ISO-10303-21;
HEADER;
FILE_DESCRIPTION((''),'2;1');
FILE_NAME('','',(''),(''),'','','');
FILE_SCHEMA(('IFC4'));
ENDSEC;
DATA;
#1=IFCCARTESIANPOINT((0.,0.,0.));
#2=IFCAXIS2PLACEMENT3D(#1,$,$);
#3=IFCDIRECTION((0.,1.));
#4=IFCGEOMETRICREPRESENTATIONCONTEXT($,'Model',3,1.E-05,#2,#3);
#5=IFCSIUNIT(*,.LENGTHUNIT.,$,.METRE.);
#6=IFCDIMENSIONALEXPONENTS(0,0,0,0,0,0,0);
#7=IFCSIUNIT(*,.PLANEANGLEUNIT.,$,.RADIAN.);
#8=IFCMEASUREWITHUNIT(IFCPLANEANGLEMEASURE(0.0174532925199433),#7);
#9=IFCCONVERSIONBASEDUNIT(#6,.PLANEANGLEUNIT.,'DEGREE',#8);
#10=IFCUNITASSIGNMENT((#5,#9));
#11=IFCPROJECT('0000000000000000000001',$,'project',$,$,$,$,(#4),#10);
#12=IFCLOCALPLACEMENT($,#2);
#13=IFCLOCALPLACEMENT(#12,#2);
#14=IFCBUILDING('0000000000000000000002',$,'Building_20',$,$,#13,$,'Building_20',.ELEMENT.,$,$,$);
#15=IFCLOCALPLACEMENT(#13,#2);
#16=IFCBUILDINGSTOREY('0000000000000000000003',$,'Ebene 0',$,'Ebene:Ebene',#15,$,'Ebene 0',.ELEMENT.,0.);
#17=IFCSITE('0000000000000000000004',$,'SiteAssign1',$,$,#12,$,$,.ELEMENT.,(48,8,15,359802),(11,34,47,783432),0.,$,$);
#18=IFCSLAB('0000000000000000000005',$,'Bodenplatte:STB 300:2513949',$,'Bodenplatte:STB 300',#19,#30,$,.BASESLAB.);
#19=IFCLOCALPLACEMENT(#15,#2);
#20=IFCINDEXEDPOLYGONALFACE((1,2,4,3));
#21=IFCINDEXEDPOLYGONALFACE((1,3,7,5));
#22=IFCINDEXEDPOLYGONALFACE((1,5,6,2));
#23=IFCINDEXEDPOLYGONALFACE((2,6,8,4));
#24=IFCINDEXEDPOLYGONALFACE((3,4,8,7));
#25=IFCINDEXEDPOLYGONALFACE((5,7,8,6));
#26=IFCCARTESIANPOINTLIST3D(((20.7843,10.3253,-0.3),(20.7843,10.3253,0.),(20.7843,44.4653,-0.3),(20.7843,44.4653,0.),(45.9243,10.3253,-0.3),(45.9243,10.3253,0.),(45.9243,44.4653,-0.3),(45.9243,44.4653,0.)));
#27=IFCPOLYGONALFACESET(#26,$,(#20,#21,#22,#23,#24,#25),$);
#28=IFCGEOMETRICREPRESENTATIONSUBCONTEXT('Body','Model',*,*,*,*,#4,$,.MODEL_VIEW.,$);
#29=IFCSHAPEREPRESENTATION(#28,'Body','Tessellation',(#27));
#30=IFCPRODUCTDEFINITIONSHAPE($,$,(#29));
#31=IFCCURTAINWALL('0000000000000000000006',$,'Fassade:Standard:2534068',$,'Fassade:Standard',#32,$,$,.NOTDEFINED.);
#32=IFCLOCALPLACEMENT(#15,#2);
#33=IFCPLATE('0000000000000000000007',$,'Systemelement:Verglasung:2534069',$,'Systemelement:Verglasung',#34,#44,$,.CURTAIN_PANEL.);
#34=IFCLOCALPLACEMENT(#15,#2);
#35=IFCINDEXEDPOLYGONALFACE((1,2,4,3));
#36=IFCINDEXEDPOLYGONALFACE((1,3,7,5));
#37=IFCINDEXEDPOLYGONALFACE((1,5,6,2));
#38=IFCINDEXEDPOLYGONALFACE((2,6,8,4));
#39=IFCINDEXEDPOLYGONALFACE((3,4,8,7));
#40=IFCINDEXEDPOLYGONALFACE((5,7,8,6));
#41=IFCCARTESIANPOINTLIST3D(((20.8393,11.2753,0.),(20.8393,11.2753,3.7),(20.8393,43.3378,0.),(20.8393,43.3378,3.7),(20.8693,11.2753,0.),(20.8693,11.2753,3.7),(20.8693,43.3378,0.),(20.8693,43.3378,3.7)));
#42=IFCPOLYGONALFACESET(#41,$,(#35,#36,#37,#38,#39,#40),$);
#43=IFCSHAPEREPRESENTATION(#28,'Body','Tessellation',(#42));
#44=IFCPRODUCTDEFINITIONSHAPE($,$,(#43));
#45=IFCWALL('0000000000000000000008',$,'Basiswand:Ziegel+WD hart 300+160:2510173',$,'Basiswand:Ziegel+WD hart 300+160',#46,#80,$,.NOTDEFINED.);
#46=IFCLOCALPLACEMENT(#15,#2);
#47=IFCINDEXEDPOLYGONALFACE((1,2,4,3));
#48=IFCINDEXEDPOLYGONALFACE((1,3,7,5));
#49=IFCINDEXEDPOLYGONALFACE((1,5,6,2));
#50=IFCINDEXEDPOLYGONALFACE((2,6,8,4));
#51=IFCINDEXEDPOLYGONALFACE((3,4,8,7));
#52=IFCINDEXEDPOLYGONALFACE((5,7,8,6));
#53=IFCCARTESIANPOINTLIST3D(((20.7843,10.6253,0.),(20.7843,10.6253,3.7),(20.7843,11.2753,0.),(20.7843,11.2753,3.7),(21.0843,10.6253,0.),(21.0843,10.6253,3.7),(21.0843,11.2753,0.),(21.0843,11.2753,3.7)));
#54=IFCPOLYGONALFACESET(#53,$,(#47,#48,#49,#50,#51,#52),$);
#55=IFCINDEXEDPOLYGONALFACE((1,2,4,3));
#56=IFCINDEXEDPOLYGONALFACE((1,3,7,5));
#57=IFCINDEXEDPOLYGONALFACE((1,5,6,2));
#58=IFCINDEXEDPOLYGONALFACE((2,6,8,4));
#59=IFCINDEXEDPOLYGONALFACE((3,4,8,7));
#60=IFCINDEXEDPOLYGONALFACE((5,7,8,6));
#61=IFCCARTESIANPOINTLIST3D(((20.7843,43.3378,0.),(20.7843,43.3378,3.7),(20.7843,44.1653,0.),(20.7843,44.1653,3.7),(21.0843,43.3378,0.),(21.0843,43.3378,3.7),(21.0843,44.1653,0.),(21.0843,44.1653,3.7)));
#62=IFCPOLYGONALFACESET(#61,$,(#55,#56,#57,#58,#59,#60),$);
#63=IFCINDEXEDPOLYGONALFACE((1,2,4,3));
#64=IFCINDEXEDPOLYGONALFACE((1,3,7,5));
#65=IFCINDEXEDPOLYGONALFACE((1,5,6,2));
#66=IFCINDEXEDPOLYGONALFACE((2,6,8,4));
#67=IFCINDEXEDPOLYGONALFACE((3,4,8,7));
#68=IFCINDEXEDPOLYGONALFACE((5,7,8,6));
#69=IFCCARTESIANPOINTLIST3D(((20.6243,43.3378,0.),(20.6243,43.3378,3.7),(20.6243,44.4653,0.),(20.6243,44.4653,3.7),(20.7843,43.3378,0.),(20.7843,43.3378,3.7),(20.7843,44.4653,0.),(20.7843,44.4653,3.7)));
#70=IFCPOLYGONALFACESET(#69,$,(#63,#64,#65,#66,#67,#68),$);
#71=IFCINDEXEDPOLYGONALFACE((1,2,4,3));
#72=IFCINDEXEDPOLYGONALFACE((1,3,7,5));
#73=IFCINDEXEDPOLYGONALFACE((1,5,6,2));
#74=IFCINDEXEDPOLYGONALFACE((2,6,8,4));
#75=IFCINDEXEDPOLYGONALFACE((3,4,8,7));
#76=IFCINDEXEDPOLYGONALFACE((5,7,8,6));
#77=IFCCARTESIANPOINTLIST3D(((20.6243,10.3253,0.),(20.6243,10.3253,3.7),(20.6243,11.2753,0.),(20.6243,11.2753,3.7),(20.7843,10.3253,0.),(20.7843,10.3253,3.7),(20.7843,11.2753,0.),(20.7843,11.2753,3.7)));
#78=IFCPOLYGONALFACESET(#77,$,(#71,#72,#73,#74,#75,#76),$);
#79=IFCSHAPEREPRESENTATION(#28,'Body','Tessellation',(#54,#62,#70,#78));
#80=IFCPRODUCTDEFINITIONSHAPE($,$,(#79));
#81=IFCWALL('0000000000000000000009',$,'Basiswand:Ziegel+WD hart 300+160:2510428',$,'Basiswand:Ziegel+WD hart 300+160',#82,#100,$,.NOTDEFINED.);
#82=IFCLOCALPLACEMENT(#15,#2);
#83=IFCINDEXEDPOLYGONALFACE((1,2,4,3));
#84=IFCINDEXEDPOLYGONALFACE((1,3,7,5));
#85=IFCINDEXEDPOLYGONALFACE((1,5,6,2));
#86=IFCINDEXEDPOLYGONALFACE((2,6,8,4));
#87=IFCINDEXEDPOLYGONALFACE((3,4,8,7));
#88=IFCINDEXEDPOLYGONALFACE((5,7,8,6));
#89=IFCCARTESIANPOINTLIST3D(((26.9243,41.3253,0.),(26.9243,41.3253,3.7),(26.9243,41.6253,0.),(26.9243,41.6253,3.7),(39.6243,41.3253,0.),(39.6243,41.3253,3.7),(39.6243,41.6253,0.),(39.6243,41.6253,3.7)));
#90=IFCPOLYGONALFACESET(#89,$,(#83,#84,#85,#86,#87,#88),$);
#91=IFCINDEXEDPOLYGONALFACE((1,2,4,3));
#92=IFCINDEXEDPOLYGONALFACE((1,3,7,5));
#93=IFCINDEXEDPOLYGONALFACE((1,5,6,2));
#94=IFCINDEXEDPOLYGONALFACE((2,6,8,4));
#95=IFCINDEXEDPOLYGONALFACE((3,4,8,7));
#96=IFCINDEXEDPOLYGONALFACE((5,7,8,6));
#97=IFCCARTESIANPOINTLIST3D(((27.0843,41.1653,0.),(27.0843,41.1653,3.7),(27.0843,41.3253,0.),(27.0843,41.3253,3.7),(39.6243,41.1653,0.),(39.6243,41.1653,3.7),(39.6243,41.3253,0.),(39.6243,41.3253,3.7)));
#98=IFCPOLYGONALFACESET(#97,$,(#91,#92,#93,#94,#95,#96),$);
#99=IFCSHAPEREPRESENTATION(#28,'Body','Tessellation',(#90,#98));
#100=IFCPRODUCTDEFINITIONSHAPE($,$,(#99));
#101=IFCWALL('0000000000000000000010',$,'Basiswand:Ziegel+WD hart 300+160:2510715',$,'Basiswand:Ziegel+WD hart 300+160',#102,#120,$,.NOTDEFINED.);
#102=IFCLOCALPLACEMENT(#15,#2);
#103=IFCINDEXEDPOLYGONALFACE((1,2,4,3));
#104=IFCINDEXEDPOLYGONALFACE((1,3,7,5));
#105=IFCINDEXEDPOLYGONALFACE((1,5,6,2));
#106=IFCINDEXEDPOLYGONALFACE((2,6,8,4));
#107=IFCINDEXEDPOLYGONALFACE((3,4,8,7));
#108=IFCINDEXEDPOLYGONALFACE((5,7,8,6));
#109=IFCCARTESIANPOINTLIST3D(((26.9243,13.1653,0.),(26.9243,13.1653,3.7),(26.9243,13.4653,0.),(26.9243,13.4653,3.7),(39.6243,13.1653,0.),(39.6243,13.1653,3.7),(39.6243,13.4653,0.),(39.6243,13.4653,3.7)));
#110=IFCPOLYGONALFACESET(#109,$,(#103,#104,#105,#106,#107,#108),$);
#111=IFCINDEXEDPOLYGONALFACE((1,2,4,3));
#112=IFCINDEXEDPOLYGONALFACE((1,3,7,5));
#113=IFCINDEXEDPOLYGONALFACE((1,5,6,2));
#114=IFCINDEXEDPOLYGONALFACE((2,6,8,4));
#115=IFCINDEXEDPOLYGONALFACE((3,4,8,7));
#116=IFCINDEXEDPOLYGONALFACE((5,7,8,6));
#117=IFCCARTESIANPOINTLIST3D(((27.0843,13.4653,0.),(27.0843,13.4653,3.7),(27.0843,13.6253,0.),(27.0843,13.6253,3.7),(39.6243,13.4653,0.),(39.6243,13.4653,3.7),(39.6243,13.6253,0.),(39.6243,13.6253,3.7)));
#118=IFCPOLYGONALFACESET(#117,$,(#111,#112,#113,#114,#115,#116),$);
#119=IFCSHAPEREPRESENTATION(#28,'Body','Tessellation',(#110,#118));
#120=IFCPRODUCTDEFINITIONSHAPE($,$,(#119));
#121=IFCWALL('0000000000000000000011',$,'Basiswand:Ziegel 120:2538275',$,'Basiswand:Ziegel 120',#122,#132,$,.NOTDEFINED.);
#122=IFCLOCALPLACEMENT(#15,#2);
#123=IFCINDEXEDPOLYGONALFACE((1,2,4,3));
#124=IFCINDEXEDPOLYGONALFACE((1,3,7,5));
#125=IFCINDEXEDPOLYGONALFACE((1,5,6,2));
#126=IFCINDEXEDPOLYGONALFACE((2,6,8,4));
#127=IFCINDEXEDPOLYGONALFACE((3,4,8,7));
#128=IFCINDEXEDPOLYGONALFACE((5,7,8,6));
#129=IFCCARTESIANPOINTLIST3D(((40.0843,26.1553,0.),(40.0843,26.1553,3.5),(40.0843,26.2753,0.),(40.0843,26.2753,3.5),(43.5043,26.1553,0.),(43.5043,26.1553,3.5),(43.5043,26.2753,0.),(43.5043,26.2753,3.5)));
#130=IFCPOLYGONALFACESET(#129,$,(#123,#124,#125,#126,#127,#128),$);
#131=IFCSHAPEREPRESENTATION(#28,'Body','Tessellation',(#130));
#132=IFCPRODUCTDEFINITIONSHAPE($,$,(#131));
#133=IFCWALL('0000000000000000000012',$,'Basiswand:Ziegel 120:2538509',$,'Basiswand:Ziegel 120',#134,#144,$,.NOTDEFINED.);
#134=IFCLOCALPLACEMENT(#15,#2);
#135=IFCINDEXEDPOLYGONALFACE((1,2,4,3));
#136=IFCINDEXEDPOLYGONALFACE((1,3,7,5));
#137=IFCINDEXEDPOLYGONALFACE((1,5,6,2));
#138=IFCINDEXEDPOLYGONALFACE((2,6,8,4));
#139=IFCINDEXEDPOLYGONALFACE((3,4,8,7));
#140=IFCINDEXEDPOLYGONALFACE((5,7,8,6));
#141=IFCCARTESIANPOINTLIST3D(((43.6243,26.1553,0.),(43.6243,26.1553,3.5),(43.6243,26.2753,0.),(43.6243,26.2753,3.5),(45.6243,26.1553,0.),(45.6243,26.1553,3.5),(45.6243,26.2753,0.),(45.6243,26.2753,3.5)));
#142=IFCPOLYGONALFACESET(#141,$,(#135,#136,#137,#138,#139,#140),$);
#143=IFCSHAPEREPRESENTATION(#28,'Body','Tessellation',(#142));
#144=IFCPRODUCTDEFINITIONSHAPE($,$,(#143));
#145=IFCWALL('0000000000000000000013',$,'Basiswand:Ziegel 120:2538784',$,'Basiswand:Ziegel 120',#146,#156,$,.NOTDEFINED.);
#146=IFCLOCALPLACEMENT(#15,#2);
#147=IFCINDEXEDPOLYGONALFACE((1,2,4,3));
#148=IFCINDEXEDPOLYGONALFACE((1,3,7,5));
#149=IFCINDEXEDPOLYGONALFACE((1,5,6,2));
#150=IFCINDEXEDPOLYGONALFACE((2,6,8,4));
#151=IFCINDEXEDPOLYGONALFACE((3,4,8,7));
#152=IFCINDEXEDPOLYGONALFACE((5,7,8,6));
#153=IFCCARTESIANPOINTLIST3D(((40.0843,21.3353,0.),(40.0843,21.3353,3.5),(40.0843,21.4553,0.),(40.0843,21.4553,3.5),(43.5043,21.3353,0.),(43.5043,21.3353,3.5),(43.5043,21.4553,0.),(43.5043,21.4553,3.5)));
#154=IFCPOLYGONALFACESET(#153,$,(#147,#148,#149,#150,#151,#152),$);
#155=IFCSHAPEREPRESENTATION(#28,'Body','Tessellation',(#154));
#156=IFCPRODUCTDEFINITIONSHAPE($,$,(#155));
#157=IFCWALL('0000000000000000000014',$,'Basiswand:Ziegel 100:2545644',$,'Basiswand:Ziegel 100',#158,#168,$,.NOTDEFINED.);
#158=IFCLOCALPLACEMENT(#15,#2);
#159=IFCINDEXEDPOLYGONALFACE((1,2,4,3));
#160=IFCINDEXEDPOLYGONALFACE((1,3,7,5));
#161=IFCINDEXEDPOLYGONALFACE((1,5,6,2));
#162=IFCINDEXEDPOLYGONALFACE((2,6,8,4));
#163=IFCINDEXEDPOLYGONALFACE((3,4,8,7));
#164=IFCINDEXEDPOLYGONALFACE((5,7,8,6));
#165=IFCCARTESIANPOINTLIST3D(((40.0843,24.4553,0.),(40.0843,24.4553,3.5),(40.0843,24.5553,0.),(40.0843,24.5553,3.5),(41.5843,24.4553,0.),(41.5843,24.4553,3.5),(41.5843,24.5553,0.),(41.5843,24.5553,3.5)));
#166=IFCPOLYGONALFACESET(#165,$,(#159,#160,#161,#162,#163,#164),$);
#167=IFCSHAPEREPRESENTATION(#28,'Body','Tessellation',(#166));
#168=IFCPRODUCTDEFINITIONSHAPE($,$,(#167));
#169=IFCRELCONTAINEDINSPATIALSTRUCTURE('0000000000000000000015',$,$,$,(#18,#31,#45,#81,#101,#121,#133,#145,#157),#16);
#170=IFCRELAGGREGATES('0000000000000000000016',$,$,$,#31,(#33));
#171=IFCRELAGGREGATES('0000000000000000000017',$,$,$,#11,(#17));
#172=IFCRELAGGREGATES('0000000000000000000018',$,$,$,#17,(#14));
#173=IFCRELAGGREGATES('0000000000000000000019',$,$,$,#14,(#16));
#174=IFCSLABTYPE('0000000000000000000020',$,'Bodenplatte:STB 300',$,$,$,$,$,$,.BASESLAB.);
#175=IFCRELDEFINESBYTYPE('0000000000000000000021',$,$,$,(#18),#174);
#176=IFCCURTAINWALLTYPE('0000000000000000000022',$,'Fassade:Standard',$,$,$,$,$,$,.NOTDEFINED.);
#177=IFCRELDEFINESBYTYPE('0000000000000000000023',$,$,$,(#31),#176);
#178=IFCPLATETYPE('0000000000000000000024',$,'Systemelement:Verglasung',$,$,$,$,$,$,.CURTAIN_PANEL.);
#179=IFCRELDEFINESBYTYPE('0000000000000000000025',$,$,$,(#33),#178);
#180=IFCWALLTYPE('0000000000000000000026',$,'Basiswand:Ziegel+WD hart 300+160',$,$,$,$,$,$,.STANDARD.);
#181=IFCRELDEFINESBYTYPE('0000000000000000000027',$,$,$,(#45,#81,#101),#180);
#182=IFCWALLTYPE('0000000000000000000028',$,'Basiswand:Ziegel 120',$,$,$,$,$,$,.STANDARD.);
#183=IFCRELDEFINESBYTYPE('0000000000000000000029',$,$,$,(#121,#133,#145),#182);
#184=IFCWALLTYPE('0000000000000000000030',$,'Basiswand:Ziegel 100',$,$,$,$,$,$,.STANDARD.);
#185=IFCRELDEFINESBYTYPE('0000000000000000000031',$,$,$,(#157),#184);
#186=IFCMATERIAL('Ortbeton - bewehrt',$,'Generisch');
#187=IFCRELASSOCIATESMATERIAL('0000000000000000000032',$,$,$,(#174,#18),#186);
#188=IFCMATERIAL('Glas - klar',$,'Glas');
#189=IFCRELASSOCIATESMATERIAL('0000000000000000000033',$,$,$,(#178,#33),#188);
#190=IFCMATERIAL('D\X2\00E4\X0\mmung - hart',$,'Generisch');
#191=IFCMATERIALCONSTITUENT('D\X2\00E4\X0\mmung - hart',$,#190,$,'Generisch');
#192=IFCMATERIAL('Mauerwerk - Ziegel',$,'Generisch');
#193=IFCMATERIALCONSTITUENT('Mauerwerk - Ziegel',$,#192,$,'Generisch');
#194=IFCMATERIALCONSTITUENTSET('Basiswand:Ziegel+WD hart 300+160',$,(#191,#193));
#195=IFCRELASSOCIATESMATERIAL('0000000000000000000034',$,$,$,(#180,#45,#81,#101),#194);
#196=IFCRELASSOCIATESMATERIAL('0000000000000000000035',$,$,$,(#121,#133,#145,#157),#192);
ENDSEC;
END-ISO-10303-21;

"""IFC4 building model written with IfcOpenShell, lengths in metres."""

from ifc_helpers import new_model, entity, si_unit, converted_unit, direction, frame, origin, place, context, subcontext, project, spatial, indexed_curve, outline, extrude, source, transform, mapped, material, constituent, constituent_set, type_object, type_shapes, element, aggregate, save


model = new_model("IFC4")

# Units and contexts
model_context = context("Model", 3, precision=1e-05, world=origin(), true_north=direction((0.0, 1.0)))
body_context = subcontext(model_context, "Body", "Model", "MODEL_VIEW")
ifc_project = project(units=[si_unit("LENGTHUNIT", "METRE"), converted_unit("PLANEANGLEUNIT", "DEGREE", entity("IfcPlaneAngleMeasure", 0.0174532925199433), si_unit("PLANEANGLEUNIT", "RADIAN"), dimensions=[0, 0, 0, 0, 0, 0, 0])], contexts=[model_context])

# Site, building, storey
site_placement = place(None, origin())
site = spatial("IfcSite", under=ifc_project, at=site_placement, Name="SiteAssign1", CompositionType="ELEMENT", RefLatitude=(48, 8, 15, 359802), RefLongitude=(11, 34, 47, 783432), RefElevation=0.0)
building_placement = place(site_placement, origin())
building = spatial("IfcBuilding", under=site, at=building_placement, Name="Building_20", LongName="Building_20", CompositionType="ELEMENT")
storey_placement = place(building_placement, origin())
storey = spatial("IfcBuildingStorey", under=building, at=storey_placement, Name="Ebene 0", ObjectType="Ebene:Ebene", LongName="Ebene 0", CompositionType="ELEMENT", Elevation=0.0)

# Slab
ifc_material_1 = material(Name="Ortbeton - bewehrt", Category="Generisch")
slab_type = type_object("IfcSlabType", Name="Bodenplatte:STB 300", PredefinedType="BASESLAB", material=ifc_material_1)
slab_placement = place(storey_placement, origin())
element("IfcSlab", 1, at=slab_placement, inside=storey, type_object=slab_type, material=ifc_material_1, Name="Bodenplatte:STB 300:2513949", ObjectType="Bodenplatte:STB 300", PredefinedType="BASESLAB", context=body_context, shape_type="SweptSolid", body=[
    extrude(outline(indexed_curve([(-17.07, -12.57), (17.07, -12.57), (17.07, 12.57), (-17.07, 12.57), (-17.07, -12.57)], self_intersect=False)), frame((33.3543, 27.3953, 0.0), z_axis=(0.0, 0.0, -1.0), x_axis=(0.0, 1.0, 0.0)), (0.0, 0.0, 1.0), 0.3),
])

# Curtain wall, plate
curtain_wall_type = type_object("IfcCurtainWallType", Name="Fassade:Standard", PredefinedType="NOTDEFINED")
curtain_wall_placement = place(storey_placement, origin())
curtain_wall = element("IfcCurtainWall", 2, at=curtain_wall_placement, inside=storey, type_object=curtain_wall_type, Name="Fassade:Standard:2534068", ObjectType="Fassade:Standard", PredefinedType="NOTDEFINED")
ifc_material_2 = material(Name="Glas - klar", Category="Glas")
plate_type = type_object("IfcPlateType", Name="Systemelement:Verglasung", PredefinedType="CURTAIN_PANEL", material=ifc_material_2)
shared_shape = source(origin(), body_context, "Body", "SweptSolid", [
    extrude(outline(indexed_curve([(-0.015, -16.0312), (0.015, -16.0312), (0.015, 16.0312), (-0.015, 16.0312), (-0.015, -16.0312)], self_intersect=False)), frame((0.0, 0.0, 0.0), z_axis=(0.0, 0.0, 1.0), x_axis=(0.0, 1.0, 0.0)), (0.0, 0.0, 1.0), 3.7),
])
type_shapes(plate_type, [shared_shape])
plate_placement = place(curtain_wall_placement, frame((20.8543, 27.3066, 0.0), z_axis=(0.0, 0.0, 1.0), x_axis=(0.0, -1.0, 0.0)))
plate = element("IfcPlate", 3, at=plate_placement, type_object=plate_type, material=ifc_material_2, Name="Systemelement:Verglasung:2534069", ObjectType="Systemelement:Verglasung", PredefinedType="CURTAIN_PANEL", context=body_context, shape_type="MappedRepresentation", body=[
    mapped(shared_shape, transform((0.0, 0.0, 0.0), scale=1.0)),
])
aggregate(curtain_wall, [plate])

# Wall, openings
ifc_material_3 = material(Name="Dämmung - hart", Category="Generisch")
ifc_constituent_1 = constituent(ifc_material_3, Name="Dämmung - hart", Category="Generisch")
ifc_material_4 = material(Name="Mauerwerk - Ziegel", Category="Generisch")
ifc_constituent_2 = constituent(ifc_material_4, Name="Mauerwerk - Ziegel", Category="Generisch")
ifc_constituent_set = constituent_set(constituents=[ifc_constituent_1, ifc_constituent_2], Name="Basiswand:Ziegel+WD hart 300+160")
wall_type_1 = type_object("IfcWallType", Name="Basiswand:Ziegel+WD hart 300+160", PredefinedType="STANDARD", material=ifc_constituent_set)
wall_1_placement = place(storey_placement, frame((20.8543, 10.6253, 0.0), z_axis=(0.0, 0.0, 1.0), x_axis=(0.0, 1.0, 0.0)))
wall_1 = element("IfcWall", 4, at=wall_1_placement, inside=storey, type_object=wall_type_1, material=ifc_constituent_set, Name="Basiswand:Ziegel+WD hart 300+160:2510173", ObjectType="Basiswand:Ziegel+WD hart 300+160", PredefinedType="NOTDEFINED", context=body_context, shape_type="SweptSolid", body=[
    extrude(outline(indexed_curve([(-0.15, -0.325), (0.15, -0.325), (0.15, 0.325), (-0.15, 0.325), (-0.15, -0.325)], self_intersect=False)), frame((0.325, -0.08, 0.0), z_axis=(0.0, 0.0, 1.0), x_axis=(0.0, 1.0, 0.0)), (0.0, 0.0, 1.0), 3.7),
    extrude(outline(indexed_curve([(-0.15, -0.4137), (0.15, -0.4137), (0.15, 0.4138), (-0.15, 0.4138), (-0.15, -0.4137)], self_intersect=False)), frame((33.1262, -0.08, 0.0), z_axis=(0.0, 0.0, 1.0), x_axis=(0.0, 1.0, 0.0)), (0.0, 0.0, 1.0), 3.7),
    extrude(outline(indexed_curve([(-0.08, -0.5637), (0.08, -0.5637), (0.08, 0.5638), (-0.08, 0.5638), (-0.08, -0.5637)], self_intersect=False)), frame((33.2762, 0.15, 0.0), z_axis=(0.0, 0.0, 1.0), x_axis=(0.0, -1.0, 0.0)), (0.0, 0.0, 1.0), 3.7),
    extrude(outline(indexed_curve([(-0.08, -0.475), (0.08, -0.475), (0.08, 0.475), (-0.08, 0.475), (-0.08, -0.475)], self_intersect=False)), frame((0.175, 0.15, 0.0), z_axis=(0.0, 0.0, 1.0), x_axis=(0.0, -1.0, 0.0)), (0.0, 0.0, 1.0), 3.7),
])
opening_1_placement = place(wall_1_placement, origin())
element("IfcOpeningElement", 5, at=opening_1_placement, cuts=wall_1, PredefinedType="OPENING", context=body_context, shape_type="SweptSolid", body=[
    extrude(outline(indexed_curve([(-16.0312, -1.85), (16.0312, -1.85), (16.0312, 1.85), (-16.0312, 1.85), (-16.0312, -1.85)], self_intersect=False)), frame((16.6812, -0.3824, 1.85), z_axis=(0.0, 1.0, 0.0), x_axis=(-1.0, 0.0, 0.0)), (0.0, 0.0, 1.0), 0.7648),
])
opening_2_placement = place(wall_1_placement, origin())
element("IfcOpeningElement", 6, at=opening_2_placement, cuts=wall_1, PredefinedType="OPENING", context=body_context, shape_type="SweptSolid", body=[
    extrude(outline(indexed_curve([(-1.65, -16.0312), (1.65, -16.0312), (1.65, 16.0312), (-1.65, 16.0312), (-1.65, -16.0312)], self_intersect=False)), frame((16.6812, 0.23, 1.85), z_axis=(0.0, -1.0, 0.0), x_axis=(0.0, 0.0, -1.0)), (0.0, 0.0, 1.0), 0.46),
])

# Walls
wall_2_placement = place(storey_placement, frame((39.6243, 41.3953, 0.0), z_axis=(0.0, 0.0, 1.0), x_axis=(-1.0, 0.0, 0.0)))
element("IfcWall", 7, at=wall_2_placement, inside=storey, type_object=wall_type_1, material=ifc_constituent_set, Name="Basiswand:Ziegel+WD hart 300+160:2510428", ObjectType="Basiswand:Ziegel+WD hart 300+160", PredefinedType="NOTDEFINED", context=body_context, shape_type="SweptSolid", body=[
    extrude(outline(indexed_curve([(-0.15, -6.35), (0.15, -6.35), (0.15, 6.35), (-0.15, 6.35), (-0.15, -6.35)], self_intersect=False)), frame((6.35, -0.08, 0.0), z_axis=(0.0, 0.0, 1.0), x_axis=(0.0, 1.0, 0.0)), (0.0, 0.0, 1.0), 3.7),
    extrude(outline(indexed_curve([(-0.08, -6.27), (0.08, -6.27), (0.08, 6.27), (-0.08, 6.27), (-0.08, -6.27)], self_intersect=False)), frame((6.27, 0.15, 0.0), z_axis=(0.0, 0.0, 1.0), x_axis=(0.0, -1.0, 0.0)), (0.0, 0.0, 1.0), 3.7),
])
wall_3_placement = place(storey_placement, frame((27.0843, 13.3953, 0.0)))
element("IfcWall", 8, at=wall_3_placement, inside=storey, type_object=wall_type_1, material=ifc_constituent_set, Name="Basiswand:Ziegel+WD hart 300+160:2510715", ObjectType="Basiswand:Ziegel+WD hart 300+160", PredefinedType="NOTDEFINED", context=body_context, shape_type="SweptSolid", body=[
    extrude(outline(indexed_curve([(-0.15, -6.35), (0.15, -6.35), (0.15, 6.35), (-0.15, 6.35), (-0.15, -6.35)], self_intersect=False)), frame((6.19, -0.08, 0.0), z_axis=(0.0, 0.0, 1.0), x_axis=(0.0, 1.0, 0.0)), (0.0, 0.0, 1.0), 3.7),
    extrude(outline(indexed_curve([(-0.08, -6.27), (0.08, -6.27), (0.08, 6.27), (-0.08, 6.27), (-0.08, -6.27)], self_intersect=False)), frame((6.27, 0.15, 0.0), z_axis=(0.0, 0.0, 1.0), x_axis=(0.0, -1.0, 0.0)), (0.0, 0.0, 1.0), 3.7),
])
wall_type_2 = type_object("IfcWallType", Name="Basiswand:Ziegel 120", PredefinedType="STANDARD")
wall_4_placement = place(storey_placement, frame((43.5043, 26.2153, 0.0), z_axis=(0.0, 0.0, 1.0), x_axis=(-1.0, 0.0, 0.0)))
element("IfcWall", 9, at=wall_4_placement, inside=storey, type_object=wall_type_2, material=ifc_material_4, Name="Basiswand:Ziegel 120:2538275", ObjectType="Basiswand:Ziegel 120", PredefinedType="NOTDEFINED", context=body_context, shape_type="SweptSolid", body=[
    extrude(outline(indexed_curve([(3.42, 0.06), (0.0, 0.06), (0.0, -0.06), (3.42, -0.06), (3.42, 0.06)], self_intersect=False)), origin(), (0.0, 0.0, 1.0), 3.5),
])
wall_5_placement = place(storey_placement, frame((43.6243, 26.2153, 0.0)))
element("IfcWall", 10, at=wall_5_placement, inside=storey, type_object=wall_type_2, material=ifc_material_4, Name="Basiswand:Ziegel 120:2538509", ObjectType="Basiswand:Ziegel 120", PredefinedType="NOTDEFINED", context=body_context, shape_type="SweptSolid", body=[
    extrude(outline(indexed_curve([(2.0, 0.06), (0.0, 0.06), (0.0, -0.06), (2.0, -0.06), (2.0, 0.06)], self_intersect=False)), origin(), (0.0, 0.0, 1.0), 3.5),
])
wall_6_placement = place(storey_placement, frame((43.5043, 21.3953, 0.0), z_axis=(0.0, 0.0, 1.0), x_axis=(-1.0, 0.0, 0.0)))
element("IfcWall", 11, at=wall_6_placement, inside=storey, type_object=wall_type_2, material=ifc_material_4, Name="Basiswand:Ziegel 120:2538784", ObjectType="Basiswand:Ziegel 120", PredefinedType="NOTDEFINED", context=body_context, shape_type="SweptSolid", body=[
    extrude(outline(indexed_curve([(3.42, 0.06), (0.0, 0.06), (0.0, -0.06), (3.42, -0.06), (3.42, 0.06)], self_intersect=False)), origin(), (0.0, 0.0, 1.0), 3.5),
])
wall_type_3 = type_object("IfcWallType", Name="Basiswand:Ziegel 100", PredefinedType="STANDARD")
wall_7_placement = place(storey_placement, frame((40.0843, 24.5053, 0.0)))
element("IfcWall", 12, at=wall_7_placement, inside=storey, type_object=wall_type_3, material=ifc_material_4, Name="Basiswand:Ziegel 100:2545644", ObjectType="Basiswand:Ziegel 100", PredefinedType="NOTDEFINED", context=body_context, shape_type="SweptSolid", body=[
    extrude(outline(indexed_curve([(1.5, 0.05), (0.0, 0.05), (0.0, -0.05), (1.5, -0.05), (1.5, 0.05)], self_intersect=False)), origin(), (0.0, 0.0, 1.0), 3.5),
])

save(model, "model.ifc")
